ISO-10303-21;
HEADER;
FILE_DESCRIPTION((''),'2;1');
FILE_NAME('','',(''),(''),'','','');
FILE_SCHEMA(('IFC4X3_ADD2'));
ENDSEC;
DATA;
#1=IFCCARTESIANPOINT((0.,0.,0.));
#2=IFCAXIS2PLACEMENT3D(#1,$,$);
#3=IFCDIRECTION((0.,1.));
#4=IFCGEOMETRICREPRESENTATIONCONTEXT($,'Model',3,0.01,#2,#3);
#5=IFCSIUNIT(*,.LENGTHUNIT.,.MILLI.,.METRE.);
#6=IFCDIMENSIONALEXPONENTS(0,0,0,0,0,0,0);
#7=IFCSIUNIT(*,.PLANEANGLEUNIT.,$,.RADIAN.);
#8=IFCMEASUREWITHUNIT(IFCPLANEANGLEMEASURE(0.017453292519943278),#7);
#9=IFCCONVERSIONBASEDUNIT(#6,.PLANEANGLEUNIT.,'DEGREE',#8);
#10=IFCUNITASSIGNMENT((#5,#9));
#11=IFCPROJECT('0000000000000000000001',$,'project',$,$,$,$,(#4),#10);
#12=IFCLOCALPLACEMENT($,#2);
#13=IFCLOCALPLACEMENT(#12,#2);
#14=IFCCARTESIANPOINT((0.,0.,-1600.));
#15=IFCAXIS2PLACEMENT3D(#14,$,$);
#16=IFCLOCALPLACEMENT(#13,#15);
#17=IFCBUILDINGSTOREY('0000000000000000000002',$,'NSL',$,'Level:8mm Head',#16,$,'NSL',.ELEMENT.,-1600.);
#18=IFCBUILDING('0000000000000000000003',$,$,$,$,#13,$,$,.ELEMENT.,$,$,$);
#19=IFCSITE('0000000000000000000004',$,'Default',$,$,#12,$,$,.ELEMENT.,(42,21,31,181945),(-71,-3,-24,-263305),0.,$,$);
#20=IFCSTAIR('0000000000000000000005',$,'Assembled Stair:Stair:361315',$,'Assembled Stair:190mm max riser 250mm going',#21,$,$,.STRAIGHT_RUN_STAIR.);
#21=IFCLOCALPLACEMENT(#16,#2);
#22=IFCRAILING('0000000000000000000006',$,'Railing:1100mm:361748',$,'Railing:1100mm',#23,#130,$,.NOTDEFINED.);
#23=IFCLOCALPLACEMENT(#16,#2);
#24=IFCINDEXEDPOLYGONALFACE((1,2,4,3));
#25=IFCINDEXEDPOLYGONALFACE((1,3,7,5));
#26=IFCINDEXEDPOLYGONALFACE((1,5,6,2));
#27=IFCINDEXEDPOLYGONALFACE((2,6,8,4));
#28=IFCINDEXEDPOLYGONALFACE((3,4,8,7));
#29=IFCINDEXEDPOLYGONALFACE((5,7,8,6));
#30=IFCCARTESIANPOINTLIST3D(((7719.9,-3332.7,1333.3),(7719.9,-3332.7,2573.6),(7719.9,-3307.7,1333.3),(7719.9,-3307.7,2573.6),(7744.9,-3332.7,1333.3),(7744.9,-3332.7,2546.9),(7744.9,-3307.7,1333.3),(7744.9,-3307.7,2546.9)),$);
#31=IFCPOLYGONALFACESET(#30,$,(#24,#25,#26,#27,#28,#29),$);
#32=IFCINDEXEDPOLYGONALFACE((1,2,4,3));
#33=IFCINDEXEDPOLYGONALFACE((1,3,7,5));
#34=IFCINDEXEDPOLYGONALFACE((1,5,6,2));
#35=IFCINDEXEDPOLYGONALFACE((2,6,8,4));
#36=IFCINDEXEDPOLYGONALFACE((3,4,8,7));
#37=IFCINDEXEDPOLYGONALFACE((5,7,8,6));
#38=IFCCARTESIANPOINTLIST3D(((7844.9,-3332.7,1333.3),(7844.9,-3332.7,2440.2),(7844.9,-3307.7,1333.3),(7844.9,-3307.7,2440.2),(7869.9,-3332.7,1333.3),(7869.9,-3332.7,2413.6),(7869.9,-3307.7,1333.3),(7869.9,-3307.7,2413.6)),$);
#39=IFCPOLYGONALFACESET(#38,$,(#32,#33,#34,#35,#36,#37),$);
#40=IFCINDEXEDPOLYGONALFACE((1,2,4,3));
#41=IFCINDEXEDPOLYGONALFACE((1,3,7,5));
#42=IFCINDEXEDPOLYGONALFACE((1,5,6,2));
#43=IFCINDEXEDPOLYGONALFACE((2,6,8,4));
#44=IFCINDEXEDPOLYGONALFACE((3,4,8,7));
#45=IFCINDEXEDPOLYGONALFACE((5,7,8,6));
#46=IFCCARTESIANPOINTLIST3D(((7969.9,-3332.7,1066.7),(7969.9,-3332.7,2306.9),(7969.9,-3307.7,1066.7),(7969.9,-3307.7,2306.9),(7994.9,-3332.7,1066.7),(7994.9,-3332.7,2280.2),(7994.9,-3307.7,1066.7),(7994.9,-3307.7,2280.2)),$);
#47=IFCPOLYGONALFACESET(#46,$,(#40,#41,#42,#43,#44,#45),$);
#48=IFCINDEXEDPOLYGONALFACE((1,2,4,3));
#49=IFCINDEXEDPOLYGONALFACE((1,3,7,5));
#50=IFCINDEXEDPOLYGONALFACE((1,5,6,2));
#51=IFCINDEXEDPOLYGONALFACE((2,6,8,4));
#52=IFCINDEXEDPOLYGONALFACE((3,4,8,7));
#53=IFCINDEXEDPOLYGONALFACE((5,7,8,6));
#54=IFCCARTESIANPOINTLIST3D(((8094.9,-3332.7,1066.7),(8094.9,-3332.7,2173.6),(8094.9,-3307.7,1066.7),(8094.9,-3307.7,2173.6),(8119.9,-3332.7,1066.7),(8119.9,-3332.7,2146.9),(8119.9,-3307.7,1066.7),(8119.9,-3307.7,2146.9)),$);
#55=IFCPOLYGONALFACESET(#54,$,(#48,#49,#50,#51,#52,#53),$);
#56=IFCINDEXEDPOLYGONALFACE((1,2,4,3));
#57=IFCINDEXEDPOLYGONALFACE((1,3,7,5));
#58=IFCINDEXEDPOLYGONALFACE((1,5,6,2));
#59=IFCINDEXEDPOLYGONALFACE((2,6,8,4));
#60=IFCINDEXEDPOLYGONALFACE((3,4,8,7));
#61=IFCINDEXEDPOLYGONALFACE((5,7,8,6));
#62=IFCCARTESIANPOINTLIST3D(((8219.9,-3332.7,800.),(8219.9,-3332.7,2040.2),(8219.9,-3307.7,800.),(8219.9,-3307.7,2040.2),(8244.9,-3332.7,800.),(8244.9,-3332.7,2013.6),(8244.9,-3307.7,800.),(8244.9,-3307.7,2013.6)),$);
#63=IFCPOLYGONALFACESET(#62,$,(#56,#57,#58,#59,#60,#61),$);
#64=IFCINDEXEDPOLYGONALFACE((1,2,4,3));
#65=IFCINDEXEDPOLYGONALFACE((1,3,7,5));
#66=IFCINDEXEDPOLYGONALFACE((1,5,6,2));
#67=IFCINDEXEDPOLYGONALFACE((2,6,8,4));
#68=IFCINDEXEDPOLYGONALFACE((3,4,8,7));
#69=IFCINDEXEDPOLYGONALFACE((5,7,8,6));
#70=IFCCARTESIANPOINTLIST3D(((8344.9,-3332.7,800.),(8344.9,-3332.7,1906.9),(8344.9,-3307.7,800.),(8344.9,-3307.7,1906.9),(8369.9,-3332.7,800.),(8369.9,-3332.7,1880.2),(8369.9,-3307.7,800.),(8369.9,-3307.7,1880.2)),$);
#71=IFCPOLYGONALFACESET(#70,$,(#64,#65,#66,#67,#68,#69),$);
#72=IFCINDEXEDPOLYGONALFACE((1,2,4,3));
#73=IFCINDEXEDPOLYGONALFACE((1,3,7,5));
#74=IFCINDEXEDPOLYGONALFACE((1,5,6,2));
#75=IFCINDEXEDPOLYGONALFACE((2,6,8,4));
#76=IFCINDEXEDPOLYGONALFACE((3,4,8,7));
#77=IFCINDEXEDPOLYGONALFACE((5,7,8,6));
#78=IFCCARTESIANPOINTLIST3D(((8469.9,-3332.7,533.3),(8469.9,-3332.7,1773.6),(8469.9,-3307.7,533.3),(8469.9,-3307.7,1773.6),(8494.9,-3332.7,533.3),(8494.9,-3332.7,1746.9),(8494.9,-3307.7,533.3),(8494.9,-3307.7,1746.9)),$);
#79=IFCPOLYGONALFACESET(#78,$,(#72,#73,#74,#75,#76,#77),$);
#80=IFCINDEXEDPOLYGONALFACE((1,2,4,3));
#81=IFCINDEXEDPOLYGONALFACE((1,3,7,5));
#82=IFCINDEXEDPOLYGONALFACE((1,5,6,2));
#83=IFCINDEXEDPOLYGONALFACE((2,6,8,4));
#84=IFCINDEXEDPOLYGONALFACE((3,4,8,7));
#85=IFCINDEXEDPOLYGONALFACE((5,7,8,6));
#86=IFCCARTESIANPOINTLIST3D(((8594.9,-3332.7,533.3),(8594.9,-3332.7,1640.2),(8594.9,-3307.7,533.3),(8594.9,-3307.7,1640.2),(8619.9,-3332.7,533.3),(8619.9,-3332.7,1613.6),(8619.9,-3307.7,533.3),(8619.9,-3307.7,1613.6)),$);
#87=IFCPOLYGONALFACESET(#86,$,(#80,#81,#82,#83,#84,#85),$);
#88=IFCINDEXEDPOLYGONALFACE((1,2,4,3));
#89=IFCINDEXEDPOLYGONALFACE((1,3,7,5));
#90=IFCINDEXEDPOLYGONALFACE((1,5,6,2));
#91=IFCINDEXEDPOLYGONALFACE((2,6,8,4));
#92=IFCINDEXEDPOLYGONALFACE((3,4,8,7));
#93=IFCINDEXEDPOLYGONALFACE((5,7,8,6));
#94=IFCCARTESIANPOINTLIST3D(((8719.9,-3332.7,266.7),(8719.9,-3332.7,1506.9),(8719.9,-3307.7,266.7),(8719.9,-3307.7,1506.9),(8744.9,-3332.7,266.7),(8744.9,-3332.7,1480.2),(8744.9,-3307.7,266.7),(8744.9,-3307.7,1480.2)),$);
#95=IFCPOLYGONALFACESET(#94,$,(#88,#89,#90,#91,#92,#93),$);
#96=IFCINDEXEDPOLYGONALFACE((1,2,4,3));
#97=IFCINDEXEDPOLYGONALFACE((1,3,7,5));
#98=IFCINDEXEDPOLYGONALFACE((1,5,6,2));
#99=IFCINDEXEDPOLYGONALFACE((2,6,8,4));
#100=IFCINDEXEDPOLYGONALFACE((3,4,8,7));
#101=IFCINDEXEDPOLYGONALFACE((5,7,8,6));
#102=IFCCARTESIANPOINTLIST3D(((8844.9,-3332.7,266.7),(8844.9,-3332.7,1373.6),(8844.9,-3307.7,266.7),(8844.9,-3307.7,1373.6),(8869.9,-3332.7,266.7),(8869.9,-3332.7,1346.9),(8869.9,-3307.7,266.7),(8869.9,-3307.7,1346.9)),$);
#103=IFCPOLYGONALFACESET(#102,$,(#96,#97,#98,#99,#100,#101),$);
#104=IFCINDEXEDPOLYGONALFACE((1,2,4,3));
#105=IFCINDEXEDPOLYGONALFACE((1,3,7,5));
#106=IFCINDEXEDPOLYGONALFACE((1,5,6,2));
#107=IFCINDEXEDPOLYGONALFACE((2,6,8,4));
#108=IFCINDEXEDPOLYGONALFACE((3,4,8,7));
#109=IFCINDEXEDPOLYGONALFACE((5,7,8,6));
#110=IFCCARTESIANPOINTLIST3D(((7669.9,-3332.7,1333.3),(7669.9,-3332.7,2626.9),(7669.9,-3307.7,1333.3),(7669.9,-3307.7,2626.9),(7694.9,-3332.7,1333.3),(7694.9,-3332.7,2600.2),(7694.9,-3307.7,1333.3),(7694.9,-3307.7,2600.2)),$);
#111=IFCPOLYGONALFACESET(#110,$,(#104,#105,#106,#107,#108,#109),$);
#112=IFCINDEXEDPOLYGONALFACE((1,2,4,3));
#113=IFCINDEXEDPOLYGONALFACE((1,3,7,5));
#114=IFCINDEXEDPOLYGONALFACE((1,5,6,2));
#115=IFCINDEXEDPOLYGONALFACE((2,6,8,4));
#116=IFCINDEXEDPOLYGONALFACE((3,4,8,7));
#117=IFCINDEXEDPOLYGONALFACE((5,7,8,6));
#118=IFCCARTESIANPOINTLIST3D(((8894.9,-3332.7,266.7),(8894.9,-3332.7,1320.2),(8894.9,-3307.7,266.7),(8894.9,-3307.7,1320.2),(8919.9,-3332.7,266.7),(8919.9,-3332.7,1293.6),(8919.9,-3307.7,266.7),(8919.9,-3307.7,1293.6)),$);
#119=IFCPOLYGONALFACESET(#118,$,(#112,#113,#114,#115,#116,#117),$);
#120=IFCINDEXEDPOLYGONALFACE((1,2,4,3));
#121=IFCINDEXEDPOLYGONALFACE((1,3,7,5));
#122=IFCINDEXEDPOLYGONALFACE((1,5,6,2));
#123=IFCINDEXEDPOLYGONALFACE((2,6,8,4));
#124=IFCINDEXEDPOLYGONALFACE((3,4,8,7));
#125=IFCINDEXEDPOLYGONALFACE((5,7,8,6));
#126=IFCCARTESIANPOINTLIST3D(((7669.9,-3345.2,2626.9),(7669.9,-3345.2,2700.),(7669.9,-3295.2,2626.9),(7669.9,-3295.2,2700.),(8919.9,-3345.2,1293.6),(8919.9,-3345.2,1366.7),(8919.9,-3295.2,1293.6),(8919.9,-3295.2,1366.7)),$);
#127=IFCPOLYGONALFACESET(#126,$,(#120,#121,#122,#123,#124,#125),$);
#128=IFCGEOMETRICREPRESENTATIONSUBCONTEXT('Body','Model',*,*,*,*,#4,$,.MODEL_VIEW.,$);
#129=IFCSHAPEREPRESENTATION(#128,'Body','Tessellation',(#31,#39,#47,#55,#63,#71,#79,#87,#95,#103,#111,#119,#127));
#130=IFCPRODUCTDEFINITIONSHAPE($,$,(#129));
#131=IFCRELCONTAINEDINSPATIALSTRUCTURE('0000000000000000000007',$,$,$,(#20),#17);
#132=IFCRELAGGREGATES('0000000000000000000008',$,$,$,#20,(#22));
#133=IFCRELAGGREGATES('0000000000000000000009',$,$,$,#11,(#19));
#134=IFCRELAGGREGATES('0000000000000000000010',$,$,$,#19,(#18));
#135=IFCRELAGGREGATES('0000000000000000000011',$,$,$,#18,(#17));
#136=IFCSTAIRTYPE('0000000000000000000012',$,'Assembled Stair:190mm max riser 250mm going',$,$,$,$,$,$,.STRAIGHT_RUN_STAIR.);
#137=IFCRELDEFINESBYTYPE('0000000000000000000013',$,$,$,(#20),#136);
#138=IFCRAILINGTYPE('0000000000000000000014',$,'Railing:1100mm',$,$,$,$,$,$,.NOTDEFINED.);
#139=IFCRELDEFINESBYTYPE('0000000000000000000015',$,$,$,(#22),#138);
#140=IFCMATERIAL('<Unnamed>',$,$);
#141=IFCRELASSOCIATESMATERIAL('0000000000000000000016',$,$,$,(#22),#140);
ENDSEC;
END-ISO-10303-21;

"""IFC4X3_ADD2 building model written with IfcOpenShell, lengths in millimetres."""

from ifc_helpers import new_model, entity, si_unit, converted_unit, direction, frame, origin, place, context, subcontext, project, spatial, polyline, outline, extrude, material, type_object, element, aggregate, save


model = new_model("IFC4X3_ADD2")

# Units and contexts
model_context = context("Model", 3, precision=0.01, world=origin(), true_north=direction((0.0, 1.0)))
body_context = subcontext(model_context, "Body", "Model", "MODEL_VIEW")
ifc_project = project(units=[si_unit("LENGTHUNIT", "METRE", prefix="MILLI"), converted_unit("PLANEANGLEUNIT", "DEGREE", entity("IfcPlaneAngleMeasure", 0.017453292519943278), si_unit("PLANEANGLEUNIT", "RADIAN"), dimensions=[0, 0, 0, 0, 0, 0, 0])], contexts=[model_context])

# Site, building, storey
site_placement = place(None, origin())
site = spatial("IfcSite", under=ifc_project, at=site_placement, Name="Default", CompositionType="ELEMENT", RefLatitude=(42, 21, 31, 181945), RefLongitude=(-71, -3, -24, -263305), RefElevation=0.0)
building_placement = place(site_placement, origin())
building = spatial("IfcBuilding", under=site, at=building_placement, CompositionType="ELEMENT")
storey_placement = place(building_placement, frame((0.0, 0.0, -1600.0)))
storey = spatial("IfcBuildingStorey", under=building, at=storey_placement, Name="NSL", ObjectType="Level:8mm Head", LongName="NSL", CompositionType="ELEMENT", Elevation=-1600.0)

# Stair
stair_type = type_object("IfcStairType", Name="Assembled Stair:190mm max riser 250mm going", PredefinedType="STRAIGHT_RUN_STAIR")
stair_placement = place(storey_placement, origin())
stair = element("IfcStair", 1, at=stair_placement, inside=storey, type_object=stair_type, Name="Assembled Stair:Stair:361315", ObjectType="Assembled Stair:190mm max riser 250mm going", PredefinedType="STRAIGHT_RUN_STAIR")
ifc_material_1 = material(Name="<Unnamed>")

# Railing
railing_type = type_object("IfcRailingType", Name="Railing:1100mm", PredefinedType="NOTDEFINED")
railing_1_placement = place(stair_placement, frame((7669.9, -3345.2, 266.7)))
railing_1 = element("IfcRailing", 2, at=railing_1_placement, type_object=railing_type, material=ifc_material_1, Name="Railing:1100mm:361748", ObjectType="Railing:1100mm", PredefinedType="NOTDEFINED", context=body_context, shape_type="SweptSolid", body=[
    extrude(outline(polyline([(-600.1, -12.5), (613.4, -12.5), (613.4, 12.5), (-626.8, 12.5), (-600.1, -12.5)])), frame((62.5, 12.5, 1680.1), z_axis=(0.0, 1.0, 0.0), x_axis=(0.0, 0.0, -1.0)), (0.0, 0.0, 1.0), 25.0),
    extrude(outline(polyline([(-533.4, -12.5), (546.8, -12.5), (546.8, 12.5), (-560.1, 12.5), (-533.4, -12.5)])), frame((187.5, 12.5, 1613.4), z_axis=(0.0, 1.0, 0.0), x_axis=(0.0, 0.0, -1.0)), (0.0, 0.0, 1.0), 25.0),
    extrude(outline(polyline([(-600.1, -12.5), (613.4, -12.5), (613.4, 12.5), (-626.8, 12.5), (-600.1, -12.5)])), frame((312.5, 12.5, 1413.4), z_axis=(0.0, 1.0, 0.0), x_axis=(0.0, 0.0, -1.0)), (0.0, 0.0, 1.0), 25.0),
    extrude(outline(polyline([(-533.4, -12.5), (546.8, -12.5), (546.8, 12.5), (-560.1, 12.5), (-533.4, -12.5)])), frame((437.5, 12.5, 1346.8), z_axis=(0.0, 1.0, 0.0), x_axis=(0.0, 0.0, -1.0)), (0.0, 0.0, 1.0), 25.0),
    extrude(outline(polyline([(-600.1, -12.5), (613.4, -12.5), (613.4, 12.5), (-626.8, 12.5), (-600.1, -12.5)])), frame((562.5, 12.5, 1146.8), z_axis=(0.0, 1.0, 0.0), x_axis=(0.0, 0.0, -1.0)), (0.0, 0.0, 1.0), 25.0),
    extrude(outline(polyline([(-533.4, -12.5), (546.8, -12.5), (546.8, 12.5), (-560.1, 12.5), (-533.4, -12.5)])), frame((687.5, 12.5, 1080.1), z_axis=(0.0, 1.0, 0.0), x_axis=(0.0, 0.0, -1.0)), (0.0, 0.0, 1.0), 25.0),
    extrude(outline(polyline([(-600.1, -12.5), (613.4, -12.5), (613.4, 12.5), (-626.8, 12.5), (-600.1, -12.5)])), frame((812.5, 12.5, 880.1), z_axis=(0.0, 1.0, 0.0), x_axis=(0.0, 0.0, -1.0)), (0.0, 0.0, 1.0), 25.0),
    extrude(outline(polyline([(-533.4, -12.5), (546.8, -12.5), (546.8, 12.5), (-560.1, 12.5), (-533.4, -12.5)])), frame((937.5, 12.5, 813.4), z_axis=(0.0, 1.0, 0.0), x_axis=(0.0, 0.0, -1.0)), (0.0, 0.0, 1.0), 25.0),
    extrude(outline(polyline([(-600.1, -12.5), (613.4, -12.5), (613.4, 12.5), (-626.8, 12.5), (-600.1, -12.5)])), frame((1062.5, 12.5, 613.4), z_axis=(0.0, 1.0, 0.0), x_axis=(0.0, 0.0, -1.0)), (0.0, 0.0, 1.0), 25.0),
    extrude(outline(polyline([(-533.4, -12.5), (546.8, -12.5), (546.8, 12.5), (-560.1, 12.5), (-533.4, -12.5)])), frame((1187.5, 12.5, 546.8), z_axis=(0.0, 1.0, 0.0), x_axis=(0.0, 0.0, -1.0)), (0.0, 0.0, 1.0), 25.0),
    extrude(outline(polyline([(-626.8, -12.5), (640.1, -12.5), (640.1, 12.5), (-653.4, 12.5), (-626.8, -12.5)])), frame((12.5, 12.5, 1706.8), z_axis=(0.0, 1.0, 0.0), x_axis=(0.0, 0.0, -1.0)), (0.0, 0.0, 1.0), 25.0),
    extrude(outline(polyline([(-506.8, -12.5), (520.1, -12.5), (520.1, 12.5), (-533.4, 12.5), (-506.8, -12.5)])), frame((1237.5, 12.5, 520.1), z_axis=(0.0, 1.0, 0.0), x_axis=(0.0, 0.0, -1.0)), (0.0, 0.0, 1.0), 25.0),
    extrude(outline(polyline([(-940.5, -25.0), (887.2, -25.0), (940.5, 25.0), (-887.2, 25.0), (-940.5, -25.0)])), frame((625.0, 0.0, 1730.1), z_axis=(0.0, 1.0, 0.0), x_axis=(-0.683941, 0.0, 0.729537)), (0.0, 0.0, 1.0), 50.0),
])
aggregate(stair, [railing_1])

save(model, "model.ifc")
